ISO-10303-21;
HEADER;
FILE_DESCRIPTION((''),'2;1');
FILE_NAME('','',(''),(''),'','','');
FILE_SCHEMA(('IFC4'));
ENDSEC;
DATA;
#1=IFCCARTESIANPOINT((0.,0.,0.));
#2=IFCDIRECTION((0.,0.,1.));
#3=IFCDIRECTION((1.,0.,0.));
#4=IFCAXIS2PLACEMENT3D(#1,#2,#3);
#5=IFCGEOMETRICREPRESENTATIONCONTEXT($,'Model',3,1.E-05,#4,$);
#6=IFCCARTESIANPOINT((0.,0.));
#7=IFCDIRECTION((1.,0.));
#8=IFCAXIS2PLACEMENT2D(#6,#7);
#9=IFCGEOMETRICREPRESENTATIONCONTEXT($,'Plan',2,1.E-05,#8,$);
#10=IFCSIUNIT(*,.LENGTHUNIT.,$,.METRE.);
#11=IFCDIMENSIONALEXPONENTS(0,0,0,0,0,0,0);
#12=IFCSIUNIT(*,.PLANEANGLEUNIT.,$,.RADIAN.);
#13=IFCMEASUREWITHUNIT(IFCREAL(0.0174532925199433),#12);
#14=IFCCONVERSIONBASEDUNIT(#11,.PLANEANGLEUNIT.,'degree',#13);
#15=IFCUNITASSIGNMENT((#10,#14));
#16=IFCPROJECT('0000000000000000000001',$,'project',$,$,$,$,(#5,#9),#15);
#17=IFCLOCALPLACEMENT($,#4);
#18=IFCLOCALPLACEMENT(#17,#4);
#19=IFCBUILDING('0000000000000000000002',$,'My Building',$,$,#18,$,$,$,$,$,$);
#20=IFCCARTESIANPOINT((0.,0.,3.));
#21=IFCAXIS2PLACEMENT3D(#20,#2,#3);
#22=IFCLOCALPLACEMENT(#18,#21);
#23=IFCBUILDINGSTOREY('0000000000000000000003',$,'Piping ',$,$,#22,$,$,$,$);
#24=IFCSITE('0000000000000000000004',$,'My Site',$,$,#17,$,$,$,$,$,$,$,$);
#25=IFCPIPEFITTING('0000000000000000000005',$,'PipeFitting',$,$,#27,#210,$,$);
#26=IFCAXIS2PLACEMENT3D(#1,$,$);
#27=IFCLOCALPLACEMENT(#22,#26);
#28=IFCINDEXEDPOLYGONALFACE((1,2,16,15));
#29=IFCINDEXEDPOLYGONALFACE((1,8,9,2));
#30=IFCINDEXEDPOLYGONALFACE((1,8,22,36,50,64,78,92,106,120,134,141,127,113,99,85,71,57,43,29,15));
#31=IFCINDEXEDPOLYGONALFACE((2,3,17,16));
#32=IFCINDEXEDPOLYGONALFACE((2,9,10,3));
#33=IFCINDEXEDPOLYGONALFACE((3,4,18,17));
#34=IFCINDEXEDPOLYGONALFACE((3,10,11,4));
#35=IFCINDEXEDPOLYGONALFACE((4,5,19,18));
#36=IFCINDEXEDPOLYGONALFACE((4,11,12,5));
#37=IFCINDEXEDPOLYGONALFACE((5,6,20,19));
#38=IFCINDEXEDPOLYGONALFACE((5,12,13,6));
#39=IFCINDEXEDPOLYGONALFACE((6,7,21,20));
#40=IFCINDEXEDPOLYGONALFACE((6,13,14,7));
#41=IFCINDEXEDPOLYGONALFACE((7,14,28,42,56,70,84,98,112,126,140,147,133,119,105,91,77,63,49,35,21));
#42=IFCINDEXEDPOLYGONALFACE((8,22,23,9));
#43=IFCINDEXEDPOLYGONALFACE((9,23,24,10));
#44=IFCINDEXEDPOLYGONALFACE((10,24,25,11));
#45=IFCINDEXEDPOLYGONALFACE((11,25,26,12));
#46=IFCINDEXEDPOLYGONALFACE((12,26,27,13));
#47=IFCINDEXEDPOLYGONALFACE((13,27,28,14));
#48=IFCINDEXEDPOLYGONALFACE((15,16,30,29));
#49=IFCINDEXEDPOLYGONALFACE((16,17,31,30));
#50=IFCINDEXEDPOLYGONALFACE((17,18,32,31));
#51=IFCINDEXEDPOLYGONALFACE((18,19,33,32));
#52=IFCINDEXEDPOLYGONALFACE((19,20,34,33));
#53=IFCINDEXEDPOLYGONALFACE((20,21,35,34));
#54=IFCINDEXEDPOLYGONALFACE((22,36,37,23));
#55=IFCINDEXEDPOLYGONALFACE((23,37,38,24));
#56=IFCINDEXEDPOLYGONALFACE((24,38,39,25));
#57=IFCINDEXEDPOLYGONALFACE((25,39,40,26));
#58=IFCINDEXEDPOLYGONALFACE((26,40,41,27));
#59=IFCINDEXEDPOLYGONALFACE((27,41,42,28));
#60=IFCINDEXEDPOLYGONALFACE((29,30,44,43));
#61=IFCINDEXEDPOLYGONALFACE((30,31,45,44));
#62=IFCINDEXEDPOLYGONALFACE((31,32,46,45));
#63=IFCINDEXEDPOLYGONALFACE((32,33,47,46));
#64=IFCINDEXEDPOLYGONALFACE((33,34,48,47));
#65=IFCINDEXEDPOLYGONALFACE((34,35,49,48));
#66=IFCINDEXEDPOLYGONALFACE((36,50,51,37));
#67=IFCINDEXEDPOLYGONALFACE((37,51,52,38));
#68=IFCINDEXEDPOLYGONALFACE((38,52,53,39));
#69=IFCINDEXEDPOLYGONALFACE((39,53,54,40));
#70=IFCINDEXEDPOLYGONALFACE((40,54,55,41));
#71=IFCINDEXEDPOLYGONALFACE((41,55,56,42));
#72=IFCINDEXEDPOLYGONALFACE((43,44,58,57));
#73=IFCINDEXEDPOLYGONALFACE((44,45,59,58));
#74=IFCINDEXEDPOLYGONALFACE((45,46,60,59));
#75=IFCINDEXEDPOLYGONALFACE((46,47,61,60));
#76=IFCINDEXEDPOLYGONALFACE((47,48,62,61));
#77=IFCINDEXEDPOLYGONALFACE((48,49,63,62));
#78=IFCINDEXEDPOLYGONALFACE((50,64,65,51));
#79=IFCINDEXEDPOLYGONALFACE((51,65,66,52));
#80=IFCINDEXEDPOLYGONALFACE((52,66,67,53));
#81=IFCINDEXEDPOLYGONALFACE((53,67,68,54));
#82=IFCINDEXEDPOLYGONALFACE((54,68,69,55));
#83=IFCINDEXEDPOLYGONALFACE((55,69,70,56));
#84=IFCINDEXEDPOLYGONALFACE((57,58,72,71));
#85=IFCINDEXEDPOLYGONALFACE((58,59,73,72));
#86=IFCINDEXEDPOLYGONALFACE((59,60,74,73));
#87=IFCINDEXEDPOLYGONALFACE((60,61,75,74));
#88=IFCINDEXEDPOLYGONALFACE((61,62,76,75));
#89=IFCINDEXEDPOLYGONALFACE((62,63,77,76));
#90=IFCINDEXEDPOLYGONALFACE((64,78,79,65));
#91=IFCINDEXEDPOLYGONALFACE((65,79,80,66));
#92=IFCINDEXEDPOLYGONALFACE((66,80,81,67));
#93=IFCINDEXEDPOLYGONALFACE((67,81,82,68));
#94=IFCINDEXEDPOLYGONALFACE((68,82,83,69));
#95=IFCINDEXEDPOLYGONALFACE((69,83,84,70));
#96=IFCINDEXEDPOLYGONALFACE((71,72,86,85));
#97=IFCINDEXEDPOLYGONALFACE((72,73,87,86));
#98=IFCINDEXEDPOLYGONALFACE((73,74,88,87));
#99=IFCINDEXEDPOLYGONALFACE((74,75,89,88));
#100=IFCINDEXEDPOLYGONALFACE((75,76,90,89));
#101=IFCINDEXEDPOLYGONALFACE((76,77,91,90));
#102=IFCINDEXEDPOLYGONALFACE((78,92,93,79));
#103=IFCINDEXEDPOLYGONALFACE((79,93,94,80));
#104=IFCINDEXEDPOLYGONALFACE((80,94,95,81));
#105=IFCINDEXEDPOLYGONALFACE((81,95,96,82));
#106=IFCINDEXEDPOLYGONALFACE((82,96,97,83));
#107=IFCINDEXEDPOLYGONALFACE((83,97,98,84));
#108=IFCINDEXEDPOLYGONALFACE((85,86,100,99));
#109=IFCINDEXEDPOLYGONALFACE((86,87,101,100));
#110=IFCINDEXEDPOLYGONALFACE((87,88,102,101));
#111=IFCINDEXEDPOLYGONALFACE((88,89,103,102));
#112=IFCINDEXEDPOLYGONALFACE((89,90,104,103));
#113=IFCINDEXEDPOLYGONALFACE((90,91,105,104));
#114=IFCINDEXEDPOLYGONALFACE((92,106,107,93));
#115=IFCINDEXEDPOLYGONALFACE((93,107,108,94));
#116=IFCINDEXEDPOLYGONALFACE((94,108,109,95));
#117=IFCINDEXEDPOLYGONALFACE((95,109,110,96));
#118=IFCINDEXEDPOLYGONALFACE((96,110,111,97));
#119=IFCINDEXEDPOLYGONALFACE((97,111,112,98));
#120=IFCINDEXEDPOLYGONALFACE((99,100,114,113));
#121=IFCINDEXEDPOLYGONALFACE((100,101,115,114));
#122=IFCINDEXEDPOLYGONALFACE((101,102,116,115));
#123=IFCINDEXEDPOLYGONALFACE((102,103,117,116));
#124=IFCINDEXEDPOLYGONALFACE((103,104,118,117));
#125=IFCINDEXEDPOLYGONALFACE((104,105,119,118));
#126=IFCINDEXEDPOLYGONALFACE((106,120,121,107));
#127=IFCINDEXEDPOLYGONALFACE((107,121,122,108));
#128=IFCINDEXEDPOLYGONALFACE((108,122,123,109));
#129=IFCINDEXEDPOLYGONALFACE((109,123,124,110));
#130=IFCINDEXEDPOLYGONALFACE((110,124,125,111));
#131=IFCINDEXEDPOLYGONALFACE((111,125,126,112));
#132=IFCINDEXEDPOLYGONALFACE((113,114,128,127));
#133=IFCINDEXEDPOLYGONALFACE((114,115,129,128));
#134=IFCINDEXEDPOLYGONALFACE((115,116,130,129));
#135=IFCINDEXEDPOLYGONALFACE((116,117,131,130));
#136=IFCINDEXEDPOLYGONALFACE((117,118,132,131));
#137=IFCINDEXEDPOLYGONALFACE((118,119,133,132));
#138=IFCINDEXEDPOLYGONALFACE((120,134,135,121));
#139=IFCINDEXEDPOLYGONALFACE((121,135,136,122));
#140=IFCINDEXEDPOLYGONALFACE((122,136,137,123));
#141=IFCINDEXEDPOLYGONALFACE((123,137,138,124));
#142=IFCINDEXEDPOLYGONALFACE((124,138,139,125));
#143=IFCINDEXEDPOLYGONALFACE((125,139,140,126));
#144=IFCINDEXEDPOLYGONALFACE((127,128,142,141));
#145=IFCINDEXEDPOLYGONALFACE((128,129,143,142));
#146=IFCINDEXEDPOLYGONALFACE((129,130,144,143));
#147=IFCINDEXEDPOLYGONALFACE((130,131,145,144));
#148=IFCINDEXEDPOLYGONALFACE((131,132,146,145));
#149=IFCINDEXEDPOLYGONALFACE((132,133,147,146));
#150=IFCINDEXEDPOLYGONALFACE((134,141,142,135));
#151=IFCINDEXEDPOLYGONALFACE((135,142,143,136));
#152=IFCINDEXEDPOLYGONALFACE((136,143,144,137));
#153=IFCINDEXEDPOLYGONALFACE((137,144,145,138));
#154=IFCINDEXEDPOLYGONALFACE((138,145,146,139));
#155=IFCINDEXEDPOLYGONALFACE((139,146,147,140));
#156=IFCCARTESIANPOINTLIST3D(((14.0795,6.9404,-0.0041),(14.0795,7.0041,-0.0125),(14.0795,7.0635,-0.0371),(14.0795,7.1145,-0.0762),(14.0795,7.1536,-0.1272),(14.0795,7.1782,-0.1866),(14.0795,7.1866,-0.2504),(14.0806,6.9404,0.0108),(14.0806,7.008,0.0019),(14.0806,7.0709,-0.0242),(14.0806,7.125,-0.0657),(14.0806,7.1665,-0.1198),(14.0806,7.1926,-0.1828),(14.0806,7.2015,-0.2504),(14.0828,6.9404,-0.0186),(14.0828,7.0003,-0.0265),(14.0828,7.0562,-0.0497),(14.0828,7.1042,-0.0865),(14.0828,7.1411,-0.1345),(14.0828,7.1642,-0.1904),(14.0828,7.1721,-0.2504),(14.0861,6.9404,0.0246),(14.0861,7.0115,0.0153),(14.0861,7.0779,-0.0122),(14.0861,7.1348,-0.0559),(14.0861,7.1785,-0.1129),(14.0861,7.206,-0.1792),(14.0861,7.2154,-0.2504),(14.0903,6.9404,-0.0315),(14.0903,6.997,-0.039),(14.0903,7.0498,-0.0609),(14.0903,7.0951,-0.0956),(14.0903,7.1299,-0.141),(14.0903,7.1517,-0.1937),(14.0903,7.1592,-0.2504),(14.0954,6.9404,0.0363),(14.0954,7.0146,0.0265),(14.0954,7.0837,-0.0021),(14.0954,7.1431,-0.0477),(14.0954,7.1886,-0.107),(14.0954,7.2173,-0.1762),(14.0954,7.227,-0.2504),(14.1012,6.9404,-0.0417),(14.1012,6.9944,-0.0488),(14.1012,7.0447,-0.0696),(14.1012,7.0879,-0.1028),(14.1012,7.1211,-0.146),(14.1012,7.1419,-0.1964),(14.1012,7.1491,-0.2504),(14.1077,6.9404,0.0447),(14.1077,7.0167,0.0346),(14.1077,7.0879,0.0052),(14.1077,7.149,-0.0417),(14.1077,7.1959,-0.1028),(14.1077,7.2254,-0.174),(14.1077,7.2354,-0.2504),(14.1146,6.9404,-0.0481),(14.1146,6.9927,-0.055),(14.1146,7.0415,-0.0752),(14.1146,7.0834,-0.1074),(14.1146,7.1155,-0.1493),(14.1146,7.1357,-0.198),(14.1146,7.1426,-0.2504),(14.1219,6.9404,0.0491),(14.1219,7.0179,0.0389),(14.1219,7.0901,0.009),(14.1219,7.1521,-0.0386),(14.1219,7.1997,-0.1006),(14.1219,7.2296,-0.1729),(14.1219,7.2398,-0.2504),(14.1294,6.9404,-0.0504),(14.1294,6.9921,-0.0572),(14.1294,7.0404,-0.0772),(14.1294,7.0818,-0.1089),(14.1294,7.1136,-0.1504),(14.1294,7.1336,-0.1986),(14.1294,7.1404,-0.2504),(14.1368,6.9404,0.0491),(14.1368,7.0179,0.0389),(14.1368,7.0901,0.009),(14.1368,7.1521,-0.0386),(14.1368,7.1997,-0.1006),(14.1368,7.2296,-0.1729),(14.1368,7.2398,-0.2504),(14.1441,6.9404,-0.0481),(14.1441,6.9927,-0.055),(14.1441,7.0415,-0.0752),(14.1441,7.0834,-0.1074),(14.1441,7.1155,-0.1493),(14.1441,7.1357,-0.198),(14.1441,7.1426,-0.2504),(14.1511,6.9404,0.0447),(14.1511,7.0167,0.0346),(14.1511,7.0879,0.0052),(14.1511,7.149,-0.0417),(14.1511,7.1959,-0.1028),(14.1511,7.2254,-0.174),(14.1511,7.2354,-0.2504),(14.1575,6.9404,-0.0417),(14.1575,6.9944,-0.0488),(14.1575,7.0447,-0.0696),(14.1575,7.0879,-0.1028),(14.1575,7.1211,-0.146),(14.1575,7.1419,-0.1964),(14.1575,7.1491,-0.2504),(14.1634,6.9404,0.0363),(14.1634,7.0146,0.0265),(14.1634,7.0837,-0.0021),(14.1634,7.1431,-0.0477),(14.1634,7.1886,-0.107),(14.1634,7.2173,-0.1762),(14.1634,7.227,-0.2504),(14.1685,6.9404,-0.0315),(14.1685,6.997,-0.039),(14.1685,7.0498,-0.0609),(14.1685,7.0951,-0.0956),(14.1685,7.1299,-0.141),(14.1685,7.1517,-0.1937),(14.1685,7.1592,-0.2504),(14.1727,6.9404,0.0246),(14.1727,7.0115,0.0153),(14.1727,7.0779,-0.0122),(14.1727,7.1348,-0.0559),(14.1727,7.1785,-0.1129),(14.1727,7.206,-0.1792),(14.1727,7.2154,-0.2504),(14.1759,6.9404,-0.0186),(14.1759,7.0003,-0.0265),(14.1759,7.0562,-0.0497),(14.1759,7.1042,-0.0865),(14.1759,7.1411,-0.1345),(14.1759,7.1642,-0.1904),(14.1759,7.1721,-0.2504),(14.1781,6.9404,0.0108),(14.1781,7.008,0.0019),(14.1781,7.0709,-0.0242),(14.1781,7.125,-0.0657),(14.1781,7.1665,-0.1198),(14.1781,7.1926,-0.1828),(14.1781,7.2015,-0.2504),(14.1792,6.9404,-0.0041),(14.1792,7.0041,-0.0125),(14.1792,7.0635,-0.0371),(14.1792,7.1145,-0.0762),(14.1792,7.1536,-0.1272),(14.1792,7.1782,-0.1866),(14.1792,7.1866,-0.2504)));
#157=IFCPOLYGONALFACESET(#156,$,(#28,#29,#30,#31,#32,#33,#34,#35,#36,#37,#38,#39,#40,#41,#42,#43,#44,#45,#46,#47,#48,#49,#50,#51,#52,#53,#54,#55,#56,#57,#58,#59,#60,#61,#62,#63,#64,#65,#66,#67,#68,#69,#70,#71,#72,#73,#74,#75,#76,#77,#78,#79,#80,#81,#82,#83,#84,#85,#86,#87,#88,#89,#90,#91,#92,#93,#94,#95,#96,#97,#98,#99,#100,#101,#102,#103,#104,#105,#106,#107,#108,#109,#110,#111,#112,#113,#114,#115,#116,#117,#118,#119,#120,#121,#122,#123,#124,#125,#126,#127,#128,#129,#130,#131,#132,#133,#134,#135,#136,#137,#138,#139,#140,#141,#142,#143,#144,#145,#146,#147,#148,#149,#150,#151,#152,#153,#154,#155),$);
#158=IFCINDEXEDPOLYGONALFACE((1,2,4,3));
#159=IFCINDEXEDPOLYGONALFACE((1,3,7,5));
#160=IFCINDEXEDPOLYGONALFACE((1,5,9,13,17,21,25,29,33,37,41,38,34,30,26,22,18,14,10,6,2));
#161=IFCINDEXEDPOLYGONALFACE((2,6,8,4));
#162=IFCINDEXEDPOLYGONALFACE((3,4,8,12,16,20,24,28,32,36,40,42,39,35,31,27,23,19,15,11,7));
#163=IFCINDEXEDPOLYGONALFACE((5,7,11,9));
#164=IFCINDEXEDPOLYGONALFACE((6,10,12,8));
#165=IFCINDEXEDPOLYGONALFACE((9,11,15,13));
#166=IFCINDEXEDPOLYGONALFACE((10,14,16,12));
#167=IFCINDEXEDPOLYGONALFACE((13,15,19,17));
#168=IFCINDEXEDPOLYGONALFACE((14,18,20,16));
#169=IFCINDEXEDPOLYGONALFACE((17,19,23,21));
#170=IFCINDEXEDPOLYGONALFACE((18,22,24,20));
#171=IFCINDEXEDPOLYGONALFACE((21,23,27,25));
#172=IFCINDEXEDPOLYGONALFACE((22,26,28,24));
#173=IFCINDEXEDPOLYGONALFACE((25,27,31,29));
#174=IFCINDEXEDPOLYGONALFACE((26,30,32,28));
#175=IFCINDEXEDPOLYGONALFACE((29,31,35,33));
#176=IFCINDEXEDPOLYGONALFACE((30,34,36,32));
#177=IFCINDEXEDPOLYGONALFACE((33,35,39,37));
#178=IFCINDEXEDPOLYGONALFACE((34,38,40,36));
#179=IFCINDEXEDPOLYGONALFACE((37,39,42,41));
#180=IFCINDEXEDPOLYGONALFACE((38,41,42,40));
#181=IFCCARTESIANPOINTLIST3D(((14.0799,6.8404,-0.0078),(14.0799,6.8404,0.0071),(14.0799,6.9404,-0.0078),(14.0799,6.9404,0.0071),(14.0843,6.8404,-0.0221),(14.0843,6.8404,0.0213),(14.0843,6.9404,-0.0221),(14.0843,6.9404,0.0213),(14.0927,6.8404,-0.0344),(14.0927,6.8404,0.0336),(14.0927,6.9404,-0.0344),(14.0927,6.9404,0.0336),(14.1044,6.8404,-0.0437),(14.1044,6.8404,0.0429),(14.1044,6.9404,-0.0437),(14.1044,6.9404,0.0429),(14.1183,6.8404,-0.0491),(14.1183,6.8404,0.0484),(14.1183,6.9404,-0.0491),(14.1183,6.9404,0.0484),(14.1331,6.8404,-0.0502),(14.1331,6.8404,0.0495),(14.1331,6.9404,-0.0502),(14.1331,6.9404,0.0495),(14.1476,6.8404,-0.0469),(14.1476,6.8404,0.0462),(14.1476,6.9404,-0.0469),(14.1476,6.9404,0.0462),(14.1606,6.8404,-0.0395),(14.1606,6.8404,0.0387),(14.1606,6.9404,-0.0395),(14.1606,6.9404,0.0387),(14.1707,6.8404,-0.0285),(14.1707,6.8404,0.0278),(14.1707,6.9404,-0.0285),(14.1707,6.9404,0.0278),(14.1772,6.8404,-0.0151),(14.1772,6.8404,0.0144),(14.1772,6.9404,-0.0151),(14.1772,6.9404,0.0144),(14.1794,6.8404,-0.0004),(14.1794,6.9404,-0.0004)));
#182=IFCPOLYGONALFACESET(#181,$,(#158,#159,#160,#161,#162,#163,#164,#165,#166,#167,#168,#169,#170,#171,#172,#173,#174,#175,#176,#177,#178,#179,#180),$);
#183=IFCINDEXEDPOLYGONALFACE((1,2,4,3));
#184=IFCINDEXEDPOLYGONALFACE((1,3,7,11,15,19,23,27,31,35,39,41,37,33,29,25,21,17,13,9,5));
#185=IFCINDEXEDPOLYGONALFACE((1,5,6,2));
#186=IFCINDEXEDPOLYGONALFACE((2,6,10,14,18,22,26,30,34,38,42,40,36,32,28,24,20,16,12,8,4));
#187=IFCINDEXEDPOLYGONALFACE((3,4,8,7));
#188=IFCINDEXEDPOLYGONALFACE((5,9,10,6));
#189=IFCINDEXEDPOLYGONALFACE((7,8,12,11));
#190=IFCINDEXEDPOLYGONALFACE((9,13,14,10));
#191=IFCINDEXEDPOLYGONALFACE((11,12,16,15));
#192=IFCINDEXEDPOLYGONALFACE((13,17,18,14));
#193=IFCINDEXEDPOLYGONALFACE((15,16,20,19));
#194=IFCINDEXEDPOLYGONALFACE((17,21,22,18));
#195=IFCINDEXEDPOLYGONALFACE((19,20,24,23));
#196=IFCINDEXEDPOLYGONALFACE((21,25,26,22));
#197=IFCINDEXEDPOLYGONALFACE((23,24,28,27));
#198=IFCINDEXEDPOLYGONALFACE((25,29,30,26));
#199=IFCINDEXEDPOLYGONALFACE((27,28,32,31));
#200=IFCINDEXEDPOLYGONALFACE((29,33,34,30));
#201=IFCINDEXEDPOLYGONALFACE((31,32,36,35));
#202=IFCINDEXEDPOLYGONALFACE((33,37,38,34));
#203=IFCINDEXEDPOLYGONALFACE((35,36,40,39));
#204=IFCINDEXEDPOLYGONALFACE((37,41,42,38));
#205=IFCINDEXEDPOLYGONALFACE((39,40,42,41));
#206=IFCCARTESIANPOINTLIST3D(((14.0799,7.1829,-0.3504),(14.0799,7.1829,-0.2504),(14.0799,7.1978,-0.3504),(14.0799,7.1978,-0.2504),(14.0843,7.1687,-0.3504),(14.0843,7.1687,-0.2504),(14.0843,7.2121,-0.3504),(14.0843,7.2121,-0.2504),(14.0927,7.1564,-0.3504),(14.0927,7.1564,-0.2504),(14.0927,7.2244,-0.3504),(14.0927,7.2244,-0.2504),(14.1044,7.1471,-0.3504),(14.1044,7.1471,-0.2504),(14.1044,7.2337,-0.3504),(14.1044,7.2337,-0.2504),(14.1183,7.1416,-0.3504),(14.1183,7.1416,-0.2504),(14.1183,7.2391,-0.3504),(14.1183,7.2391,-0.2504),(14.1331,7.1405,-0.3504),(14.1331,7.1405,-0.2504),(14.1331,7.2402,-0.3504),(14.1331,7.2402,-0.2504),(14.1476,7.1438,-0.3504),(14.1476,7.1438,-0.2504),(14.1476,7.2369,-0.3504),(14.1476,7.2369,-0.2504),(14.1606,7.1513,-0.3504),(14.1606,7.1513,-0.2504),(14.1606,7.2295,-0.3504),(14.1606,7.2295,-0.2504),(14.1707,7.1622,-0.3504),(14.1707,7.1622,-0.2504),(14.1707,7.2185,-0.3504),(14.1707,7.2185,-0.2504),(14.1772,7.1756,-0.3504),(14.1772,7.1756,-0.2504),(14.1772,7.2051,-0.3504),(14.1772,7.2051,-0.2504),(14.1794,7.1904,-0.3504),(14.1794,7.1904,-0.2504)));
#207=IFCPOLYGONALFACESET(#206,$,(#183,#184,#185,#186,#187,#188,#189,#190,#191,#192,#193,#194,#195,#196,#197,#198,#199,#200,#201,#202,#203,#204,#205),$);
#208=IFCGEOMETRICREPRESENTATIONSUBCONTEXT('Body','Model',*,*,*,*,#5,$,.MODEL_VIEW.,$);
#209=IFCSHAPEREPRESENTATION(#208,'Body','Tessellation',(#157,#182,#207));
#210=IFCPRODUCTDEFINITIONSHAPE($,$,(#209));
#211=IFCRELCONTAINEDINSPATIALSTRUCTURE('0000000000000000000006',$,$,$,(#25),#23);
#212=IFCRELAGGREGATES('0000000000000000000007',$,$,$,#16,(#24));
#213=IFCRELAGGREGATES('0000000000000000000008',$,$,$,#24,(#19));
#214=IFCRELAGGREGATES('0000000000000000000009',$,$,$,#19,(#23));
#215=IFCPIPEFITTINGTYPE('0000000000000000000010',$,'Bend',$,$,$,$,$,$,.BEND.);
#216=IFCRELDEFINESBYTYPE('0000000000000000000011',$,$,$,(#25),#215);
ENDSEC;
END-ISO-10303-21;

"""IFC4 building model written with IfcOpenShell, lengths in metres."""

from ifc_helpers import new_model, entity, si_unit, converted_unit, frame, origin_with_axes, origin_2d_with_axis, place, context, subcontext, project, spatial, circle, extrude, source, transform, mapped, type_object, type_shapes, element, save


model = new_model("IFC4")

# Units and contexts
model_context = context("Model", 3, precision=1e-05, world=origin_with_axes())
plan_context = context("Plan", 2, precision=1e-05, world=origin_2d_with_axis())
body_context = subcontext(model_context, "Body", "Model", "MODEL_VIEW")
ifc_project = project(units=[si_unit("LENGTHUNIT", "METRE"), converted_unit("PLANEANGLEUNIT", "degree", entity("IfcReal", 0.0174532925199433), si_unit("PLANEANGLEUNIT", "RADIAN"), dimensions=[0, 0, 0, 0, 0, 0, 0])], contexts=[model_context, plan_context])

# Site, building, storey
site_placement = place(None, origin_with_axes())
site = spatial("IfcSite", under=ifc_project, at=site_placement, Name="My Site")
building_placement = place(site_placement, origin_with_axes())
building = spatial("IfcBuilding", under=site, at=building_placement, Name="My Building")
storey_placement = place(building_placement, frame((0.0, 0.0, 3.0), z_axis=(0.0, 0.0, 1.0), x_axis=(1.0, 0.0, 0.0)))
storey = spatial("IfcBuildingStorey", under=building, at=storey_placement, Name="Piping ")

# Pipe fitting
pipe_fitting_type = type_object("IfcPipeFittingType", Name="Bend", PredefinedType="BEND")
shared_shape = source(origin_with_axes(), body_context, "Body", "SolidModel", [
    entity("IfcSweptDiskSolid", entity("IfcIndexedPolyCurve", entity("IfcCartesianPointList3D", [[0.0, 0.0, -0.1], [0.0, -0.0732, -0.2768], [0.0, -0.25, -0.35]]), [entity("IfcArcIndex", [1, 2, 3])]), 0.05),
    extrude(circle(Radius=0.05), origin_with_axes(), (0.0, 0.0, -1.0), 0.1),
    extrude(circle(Radius=0.05), frame((0.0, -0.25, -0.35), z_axis=(0.0, -1.0, 0.0), x_axis=(1.0, 0.0, 0.0)), (0.0, 0.0, 1.0), 0.1),
])
type_shapes(pipe_fitting_type, [shared_shape])
for number, where, z_axis, x_axis, name in (
    (1, (14.1294, 6.8404, -0.0004), (0.0, -1.0, 0.0), (1.0, 0.0, 0.0), "PipeFitting"),
):
    element("IfcPipeFitting", number, at=place(storey_placement, frame(where, z_axis=z_axis, x_axis=x_axis)), inside=storey, type_object=pipe_fitting_type, Name=name, context=body_context, shape_type="MappedRepresentation", body=[
        mapped(shared_shape, transform((0.0, 0.0, 0.0), x_axis=(1.0, 0.0, 0.0), y_axis=(0.0, 1.0, 0.0), z_axis=(0.0, 0.0, 1.0), scale=1.0)),
    ])

save(model, "model.ifc")
